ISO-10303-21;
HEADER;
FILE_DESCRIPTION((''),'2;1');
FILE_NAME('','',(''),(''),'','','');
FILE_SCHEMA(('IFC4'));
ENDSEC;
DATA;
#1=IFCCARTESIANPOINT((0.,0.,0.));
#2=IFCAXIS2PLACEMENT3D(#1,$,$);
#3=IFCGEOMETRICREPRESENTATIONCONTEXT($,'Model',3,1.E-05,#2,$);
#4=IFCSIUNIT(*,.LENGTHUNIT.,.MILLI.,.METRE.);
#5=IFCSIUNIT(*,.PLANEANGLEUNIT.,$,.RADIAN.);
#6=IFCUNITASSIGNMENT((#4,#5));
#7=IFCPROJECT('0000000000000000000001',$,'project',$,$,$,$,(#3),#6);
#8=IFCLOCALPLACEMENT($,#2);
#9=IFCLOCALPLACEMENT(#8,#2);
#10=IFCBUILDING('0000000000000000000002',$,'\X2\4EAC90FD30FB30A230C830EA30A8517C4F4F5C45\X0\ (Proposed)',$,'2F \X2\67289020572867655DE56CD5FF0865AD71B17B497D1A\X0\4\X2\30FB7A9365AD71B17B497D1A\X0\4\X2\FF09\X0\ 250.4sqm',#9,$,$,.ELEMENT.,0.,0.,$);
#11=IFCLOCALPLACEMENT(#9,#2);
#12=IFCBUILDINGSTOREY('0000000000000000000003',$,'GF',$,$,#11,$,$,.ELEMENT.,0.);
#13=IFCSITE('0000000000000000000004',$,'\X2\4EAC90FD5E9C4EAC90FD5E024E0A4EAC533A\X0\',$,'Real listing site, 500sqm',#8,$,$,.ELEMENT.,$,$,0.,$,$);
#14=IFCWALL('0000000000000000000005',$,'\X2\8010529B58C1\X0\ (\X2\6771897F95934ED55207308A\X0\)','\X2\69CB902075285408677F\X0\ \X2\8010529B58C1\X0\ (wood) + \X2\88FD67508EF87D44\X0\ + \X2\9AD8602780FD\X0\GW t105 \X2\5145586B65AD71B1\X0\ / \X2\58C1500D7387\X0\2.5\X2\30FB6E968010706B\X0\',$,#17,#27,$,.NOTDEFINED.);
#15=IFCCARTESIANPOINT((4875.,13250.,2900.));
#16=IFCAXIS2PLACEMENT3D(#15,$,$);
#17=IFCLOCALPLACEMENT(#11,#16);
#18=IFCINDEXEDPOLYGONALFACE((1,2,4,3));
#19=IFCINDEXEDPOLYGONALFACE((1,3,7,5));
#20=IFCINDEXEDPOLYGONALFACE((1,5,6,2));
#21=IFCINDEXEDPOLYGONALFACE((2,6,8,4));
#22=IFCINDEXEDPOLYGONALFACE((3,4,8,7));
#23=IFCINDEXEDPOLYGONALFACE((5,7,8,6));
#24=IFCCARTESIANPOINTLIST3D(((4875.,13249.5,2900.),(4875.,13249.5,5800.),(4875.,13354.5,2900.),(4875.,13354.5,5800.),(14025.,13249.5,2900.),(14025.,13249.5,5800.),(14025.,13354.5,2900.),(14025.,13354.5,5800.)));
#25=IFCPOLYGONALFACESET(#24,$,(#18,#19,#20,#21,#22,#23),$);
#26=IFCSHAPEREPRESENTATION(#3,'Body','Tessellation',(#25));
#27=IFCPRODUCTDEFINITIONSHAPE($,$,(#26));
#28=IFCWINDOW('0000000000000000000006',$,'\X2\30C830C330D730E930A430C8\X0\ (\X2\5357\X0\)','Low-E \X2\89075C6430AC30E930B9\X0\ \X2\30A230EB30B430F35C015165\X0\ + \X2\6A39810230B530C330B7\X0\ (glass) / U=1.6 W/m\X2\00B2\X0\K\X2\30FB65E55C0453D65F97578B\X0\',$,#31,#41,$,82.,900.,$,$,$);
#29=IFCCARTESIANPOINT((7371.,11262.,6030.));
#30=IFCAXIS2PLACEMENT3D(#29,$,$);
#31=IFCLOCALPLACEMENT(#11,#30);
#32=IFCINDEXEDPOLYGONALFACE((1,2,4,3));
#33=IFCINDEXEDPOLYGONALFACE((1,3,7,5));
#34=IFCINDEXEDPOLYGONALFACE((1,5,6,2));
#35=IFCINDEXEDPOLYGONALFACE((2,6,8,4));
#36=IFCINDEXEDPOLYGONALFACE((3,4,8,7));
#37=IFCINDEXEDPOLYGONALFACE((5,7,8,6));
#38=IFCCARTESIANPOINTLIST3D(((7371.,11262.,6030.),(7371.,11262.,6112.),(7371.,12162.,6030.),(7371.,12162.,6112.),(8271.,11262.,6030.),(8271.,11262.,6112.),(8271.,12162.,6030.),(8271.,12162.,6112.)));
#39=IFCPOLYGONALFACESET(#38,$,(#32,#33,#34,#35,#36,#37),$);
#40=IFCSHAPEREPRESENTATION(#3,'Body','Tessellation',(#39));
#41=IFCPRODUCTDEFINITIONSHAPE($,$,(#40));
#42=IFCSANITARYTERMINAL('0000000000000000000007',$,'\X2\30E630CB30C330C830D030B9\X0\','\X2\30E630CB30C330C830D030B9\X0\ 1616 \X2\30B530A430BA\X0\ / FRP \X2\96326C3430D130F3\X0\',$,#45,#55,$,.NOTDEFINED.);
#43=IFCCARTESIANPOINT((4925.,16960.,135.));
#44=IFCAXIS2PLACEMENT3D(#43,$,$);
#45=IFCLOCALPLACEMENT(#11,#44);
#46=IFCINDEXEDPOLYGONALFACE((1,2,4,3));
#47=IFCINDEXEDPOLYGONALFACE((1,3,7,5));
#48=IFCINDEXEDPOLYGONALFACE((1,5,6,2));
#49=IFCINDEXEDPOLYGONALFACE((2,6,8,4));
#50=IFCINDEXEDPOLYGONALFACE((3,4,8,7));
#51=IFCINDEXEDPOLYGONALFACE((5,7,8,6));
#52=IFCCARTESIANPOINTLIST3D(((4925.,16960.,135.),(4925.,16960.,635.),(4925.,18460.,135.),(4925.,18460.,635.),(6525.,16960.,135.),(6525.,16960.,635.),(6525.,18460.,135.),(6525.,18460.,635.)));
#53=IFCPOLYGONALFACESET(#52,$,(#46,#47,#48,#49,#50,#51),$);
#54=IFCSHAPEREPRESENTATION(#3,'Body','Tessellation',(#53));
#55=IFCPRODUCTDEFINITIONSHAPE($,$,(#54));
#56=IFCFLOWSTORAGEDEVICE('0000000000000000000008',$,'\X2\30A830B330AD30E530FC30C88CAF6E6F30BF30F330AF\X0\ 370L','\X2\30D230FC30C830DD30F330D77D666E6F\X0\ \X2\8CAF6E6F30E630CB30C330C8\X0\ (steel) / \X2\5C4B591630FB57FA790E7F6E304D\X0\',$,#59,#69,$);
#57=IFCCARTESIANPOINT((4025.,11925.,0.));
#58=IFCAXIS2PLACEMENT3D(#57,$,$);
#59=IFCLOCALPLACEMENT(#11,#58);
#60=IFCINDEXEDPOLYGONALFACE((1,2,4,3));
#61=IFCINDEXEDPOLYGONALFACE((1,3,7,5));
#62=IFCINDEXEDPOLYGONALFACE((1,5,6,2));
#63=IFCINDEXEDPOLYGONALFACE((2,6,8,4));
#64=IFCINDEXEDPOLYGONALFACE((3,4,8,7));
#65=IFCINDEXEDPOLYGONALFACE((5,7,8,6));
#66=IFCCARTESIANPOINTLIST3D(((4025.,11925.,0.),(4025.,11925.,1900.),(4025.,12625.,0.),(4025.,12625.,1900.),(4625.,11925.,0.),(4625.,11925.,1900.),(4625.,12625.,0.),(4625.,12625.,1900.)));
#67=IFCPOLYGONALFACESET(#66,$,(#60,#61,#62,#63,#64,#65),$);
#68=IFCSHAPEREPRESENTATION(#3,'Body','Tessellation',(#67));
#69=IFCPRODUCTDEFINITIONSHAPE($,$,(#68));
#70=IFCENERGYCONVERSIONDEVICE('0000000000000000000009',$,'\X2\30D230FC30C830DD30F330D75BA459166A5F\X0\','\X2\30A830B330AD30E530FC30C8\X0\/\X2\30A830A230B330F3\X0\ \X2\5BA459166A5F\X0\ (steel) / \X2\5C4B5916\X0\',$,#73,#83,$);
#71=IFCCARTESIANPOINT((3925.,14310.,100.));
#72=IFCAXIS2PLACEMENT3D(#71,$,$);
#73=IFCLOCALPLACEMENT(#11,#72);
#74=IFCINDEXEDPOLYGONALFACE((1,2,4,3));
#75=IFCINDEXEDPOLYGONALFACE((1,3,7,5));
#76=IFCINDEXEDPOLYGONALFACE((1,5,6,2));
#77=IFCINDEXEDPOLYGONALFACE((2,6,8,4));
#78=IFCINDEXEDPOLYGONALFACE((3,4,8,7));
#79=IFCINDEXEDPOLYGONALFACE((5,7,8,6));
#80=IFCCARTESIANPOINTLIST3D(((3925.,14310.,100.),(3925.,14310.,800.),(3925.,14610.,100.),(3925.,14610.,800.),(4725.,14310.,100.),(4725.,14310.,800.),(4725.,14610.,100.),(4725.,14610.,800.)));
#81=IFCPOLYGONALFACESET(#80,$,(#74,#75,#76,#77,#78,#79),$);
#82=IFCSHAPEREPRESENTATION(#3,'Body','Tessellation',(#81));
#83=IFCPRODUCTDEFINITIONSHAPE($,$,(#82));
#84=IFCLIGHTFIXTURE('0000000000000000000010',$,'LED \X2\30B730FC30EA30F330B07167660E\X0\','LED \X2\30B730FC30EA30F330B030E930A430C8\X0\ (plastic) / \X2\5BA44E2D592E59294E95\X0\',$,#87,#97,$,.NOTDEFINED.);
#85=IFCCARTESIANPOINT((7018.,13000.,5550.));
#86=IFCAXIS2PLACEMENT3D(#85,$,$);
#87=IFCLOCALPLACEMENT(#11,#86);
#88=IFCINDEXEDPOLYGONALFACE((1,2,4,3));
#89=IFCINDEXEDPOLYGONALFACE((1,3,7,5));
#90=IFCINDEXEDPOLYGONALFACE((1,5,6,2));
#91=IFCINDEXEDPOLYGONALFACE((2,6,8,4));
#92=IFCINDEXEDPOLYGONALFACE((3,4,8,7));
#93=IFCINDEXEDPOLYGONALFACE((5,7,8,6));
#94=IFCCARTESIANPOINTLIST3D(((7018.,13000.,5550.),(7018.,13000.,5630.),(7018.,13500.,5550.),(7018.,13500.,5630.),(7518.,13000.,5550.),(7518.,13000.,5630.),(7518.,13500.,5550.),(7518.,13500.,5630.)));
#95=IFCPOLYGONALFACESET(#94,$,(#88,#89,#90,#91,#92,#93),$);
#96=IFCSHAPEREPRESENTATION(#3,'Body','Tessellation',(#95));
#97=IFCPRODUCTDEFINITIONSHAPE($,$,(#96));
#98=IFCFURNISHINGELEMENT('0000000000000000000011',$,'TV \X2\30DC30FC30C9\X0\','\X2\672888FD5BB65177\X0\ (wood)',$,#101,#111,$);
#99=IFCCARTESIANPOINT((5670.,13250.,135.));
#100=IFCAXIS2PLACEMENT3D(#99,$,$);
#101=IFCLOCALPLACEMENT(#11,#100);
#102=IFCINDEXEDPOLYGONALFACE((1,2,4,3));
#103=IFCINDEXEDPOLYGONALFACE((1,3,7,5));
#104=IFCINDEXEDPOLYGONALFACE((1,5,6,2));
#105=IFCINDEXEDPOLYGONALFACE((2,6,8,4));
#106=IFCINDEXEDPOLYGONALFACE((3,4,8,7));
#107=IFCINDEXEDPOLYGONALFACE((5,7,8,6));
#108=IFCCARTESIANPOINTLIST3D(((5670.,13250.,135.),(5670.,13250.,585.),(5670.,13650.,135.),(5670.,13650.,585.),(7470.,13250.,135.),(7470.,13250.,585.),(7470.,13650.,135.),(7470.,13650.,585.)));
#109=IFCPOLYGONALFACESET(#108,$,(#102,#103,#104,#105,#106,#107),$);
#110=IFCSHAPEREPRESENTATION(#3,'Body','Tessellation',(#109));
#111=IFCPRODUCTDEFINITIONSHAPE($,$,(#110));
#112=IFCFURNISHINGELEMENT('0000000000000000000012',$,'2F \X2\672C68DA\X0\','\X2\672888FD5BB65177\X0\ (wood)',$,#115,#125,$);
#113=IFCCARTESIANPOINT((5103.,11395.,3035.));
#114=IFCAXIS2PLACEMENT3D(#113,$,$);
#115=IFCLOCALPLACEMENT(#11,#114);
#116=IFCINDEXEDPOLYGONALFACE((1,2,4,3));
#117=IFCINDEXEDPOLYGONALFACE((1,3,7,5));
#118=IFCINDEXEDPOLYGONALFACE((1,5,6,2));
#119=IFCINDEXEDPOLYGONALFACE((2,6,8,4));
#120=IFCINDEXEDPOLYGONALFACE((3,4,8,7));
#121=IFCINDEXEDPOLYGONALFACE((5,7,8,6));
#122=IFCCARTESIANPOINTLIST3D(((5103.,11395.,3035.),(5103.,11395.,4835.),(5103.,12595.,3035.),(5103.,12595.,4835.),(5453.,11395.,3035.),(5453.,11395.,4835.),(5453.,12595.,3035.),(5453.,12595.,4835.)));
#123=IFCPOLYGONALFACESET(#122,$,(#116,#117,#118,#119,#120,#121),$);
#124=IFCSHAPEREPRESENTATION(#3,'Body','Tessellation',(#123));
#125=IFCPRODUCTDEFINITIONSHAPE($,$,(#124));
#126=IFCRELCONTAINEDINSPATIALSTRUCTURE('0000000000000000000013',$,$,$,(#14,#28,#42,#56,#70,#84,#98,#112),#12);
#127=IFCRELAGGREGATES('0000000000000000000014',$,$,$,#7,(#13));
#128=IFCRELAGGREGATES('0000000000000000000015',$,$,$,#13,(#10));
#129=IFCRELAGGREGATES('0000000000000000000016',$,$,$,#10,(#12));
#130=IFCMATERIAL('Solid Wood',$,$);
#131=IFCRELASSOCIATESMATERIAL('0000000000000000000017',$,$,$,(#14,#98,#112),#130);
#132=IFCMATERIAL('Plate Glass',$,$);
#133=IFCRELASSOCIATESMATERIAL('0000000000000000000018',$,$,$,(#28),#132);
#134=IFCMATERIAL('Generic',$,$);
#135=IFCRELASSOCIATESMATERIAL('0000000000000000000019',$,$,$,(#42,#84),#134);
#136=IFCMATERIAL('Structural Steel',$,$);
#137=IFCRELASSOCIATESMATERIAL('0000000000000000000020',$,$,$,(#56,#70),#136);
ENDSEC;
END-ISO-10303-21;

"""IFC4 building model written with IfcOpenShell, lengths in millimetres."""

from ifc_helpers import new_model, si_unit, frame, frame_2d, origin, place, context, project, spatial, rectangle, extrude, material, element, save


model = new_model("IFC4")

# Units and contexts
model_context = context("Model", 3, precision=1e-05, world=origin())
ifc_project = project(units=[si_unit("LENGTHUNIT", "METRE", prefix="MILLI"), si_unit("PLANEANGLEUNIT", "RADIAN")], contexts=[model_context])

# Site, building, storey
site_placement = place(None, origin())
site = spatial("IfcSite", under=ifc_project, at=site_placement, Name="京都府京都市上京区", ObjectType="Real listing site, 500sqm", CompositionType="ELEMENT", RefElevation=0.0)
building_placement = place(site_placement, origin())
building = spatial("IfcBuilding", under=site, at=building_placement, Name="京都・アトリエ兼住居 (Proposed)", ObjectType="2F 木造在来工法（断熱等級4・窓断熱等級4） 250.4sqm", CompositionType="ELEMENT", ElevationOfRefHeight=0.0, ElevationOfTerrain=0.0)
storey_placement = place(building_placement, origin())
storey = spatial("IfcBuildingStorey", under=building, at=storey_placement, Name="GF", CompositionType="ELEMENT", Elevation=0.0)

# Shared definitions
ifc_material_1 = material(Name="Solid Wood")

# Wall
wall_1_placement = place(storey_placement, frame((4875.0, 13250.0, 2900.0)))
element("IfcWall", 1, at=wall_1_placement, inside=storey, material=ifc_material_1, Name="耐力壁 (東西間仕切り)", Description="構造用合板 耐力壁 (wood) + 製材軸組 + 高性能GW t105 充填断熱 / 壁倍率2.5・準耐火", PredefinedType="NOTDEFINED", context=model_context, shape_type="SweptSolid", body=[
    extrude(rectangle(XDim=9150.0, YDim=105.0, at=frame_2d((4575.0, 52.0))), frame((4875.0, 13250.0, 2900.0)), (0.0, 0.0, 1.0), 2900.0),
])

# Window
ifc_material_2 = material(Name="Plate Glass")
window_placement = place(storey_placement, frame((7371.0, 11262.0, 6030.0)))
element("IfcWindow", 2, at=window_placement, inside=storey, material=ifc_material_2, Name="トップライト (南)", Description="Low-E 複層ガラス アルゴン封入 + 樹脂サッシ (glass) / U=1.6 W/m²K・日射取得型", OverallHeight=82.0, OverallWidth=900.0, context=model_context, shape_type="SweptSolid", body=[
    extrude(rectangle(XDim=900.0, YDim=900.0, at=frame_2d((450.0, 450.0))), frame((7371.0, 11262.0, 6030.0)), (0.0, 0.0, 1.0), 82.0),
])

# Sanitary terminal
ifc_material_3 = material(Name="Generic")
sanitary_terminal_placement = place(storey_placement, frame((4925.0, 16960.0, 135.0)))
element("IfcSanitaryTerminal", 3, at=sanitary_terminal_placement, inside=storey, material=ifc_material_3, Name="ユニットバス", Description="ユニットバス 1616 サイズ / FRP 防水パン", PredefinedType="NOTDEFINED", context=model_context, shape_type="SweptSolid", body=[
    extrude(rectangle(XDim=1600.0, YDim=1500.0, at=frame_2d((800.0, 750.0))), frame((4925.0, 16960.0, 135.0)), (0.0, 0.0, 1.0), 500.0),
])

# Flow storage device
ifc_material_4 = material(Name="Structural Steel")
flow_storage_device_placement = place(storey_placement, frame((4025.0, 11925.0, 0.0)))
element("IfcFlowStorageDevice", 4, at=flow_storage_device_placement, inside=storey, material=ifc_material_4, Name="エコキュート貯湯タンク 370L", Description="ヒートポンプ給湯 貯湯ユニット (steel) / 屋外・基礎置き", context=model_context, shape_type="SweptSolid", body=[
    extrude(rectangle(XDim=600.0, YDim=700.0, at=frame_2d((300.0, 350.0))), frame((4025.0, 11925.0, 0.0)), (0.0, 0.0, 1.0), 1900.0),
])

# Energy conversion device
energy_conversion_device_placement = place(storey_placement, frame((3925.0, 14310.0, 100.0)))
element("IfcEnergyConversionDevice", 5, at=energy_conversion_device_placement, inside=storey, material=ifc_material_4, Name="ヒートポンプ室外機", Description="エコキュート/エアコン 室外機 (steel) / 屋外", context=model_context, shape_type="SweptSolid", body=[
    extrude(rectangle(XDim=800.0, YDim=300.0, at=frame_2d((400.0, 150.0))), frame((3925.0, 14310.0, 100.0)), (0.0, 0.0, 1.0), 700.0),
])

# Light fixture
light_fixture_placement = place(storey_placement, frame((7018.0, 13000.0, 5550.0)))
element("IfcLightFixture", 6, at=light_fixture_placement, inside=storey, material=ifc_material_3, Name="LED シーリング照明", Description="LED シーリングライト (plastic) / 室中央天井", PredefinedType="NOTDEFINED", context=model_context, shape_type="SweptSolid", body=[
    extrude(rectangle(XDim=500.0, YDim=500.0, at=frame_2d((250.0, 250.0))), frame((7018.0, 13000.0, 5550.0)), (0.0, 0.0, 1.0), 80.0),
])

# Furnishing elements
furnishing_1_placement = place(storey_placement, frame((5670.0, 13250.0, 135.0)))
element("IfcFurnishingElement", 7, at=furnishing_1_placement, inside=storey, material=ifc_material_1, Name="TV ボード", Description="木製家具 (wood)", context=model_context, shape_type="SweptSolid", body=[
    extrude(rectangle(XDim=1800.0, YDim=400.0, at=frame_2d((900.0, 200.0))), frame((5670.0, 13250.0, 135.0)), (0.0, 0.0, 1.0), 450.0),
])
furnishing_2_placement = place(storey_placement, frame((5103.0, 11395.0, 3035.0)))
element("IfcFurnishingElement", 8, at=furnishing_2_placement, inside=storey, material=ifc_material_1, Name="2F 本棚", Description="木製家具 (wood)", context=model_context, shape_type="SweptSolid", body=[
    extrude(rectangle(XDim=350.0, YDim=1200.0, at=frame_2d((175.0, 600.0))), frame((5103.0, 11395.0, 3035.0)), (0.0, 0.0, 1.0), 1800.0),
])

save(model, "model.ifc")
